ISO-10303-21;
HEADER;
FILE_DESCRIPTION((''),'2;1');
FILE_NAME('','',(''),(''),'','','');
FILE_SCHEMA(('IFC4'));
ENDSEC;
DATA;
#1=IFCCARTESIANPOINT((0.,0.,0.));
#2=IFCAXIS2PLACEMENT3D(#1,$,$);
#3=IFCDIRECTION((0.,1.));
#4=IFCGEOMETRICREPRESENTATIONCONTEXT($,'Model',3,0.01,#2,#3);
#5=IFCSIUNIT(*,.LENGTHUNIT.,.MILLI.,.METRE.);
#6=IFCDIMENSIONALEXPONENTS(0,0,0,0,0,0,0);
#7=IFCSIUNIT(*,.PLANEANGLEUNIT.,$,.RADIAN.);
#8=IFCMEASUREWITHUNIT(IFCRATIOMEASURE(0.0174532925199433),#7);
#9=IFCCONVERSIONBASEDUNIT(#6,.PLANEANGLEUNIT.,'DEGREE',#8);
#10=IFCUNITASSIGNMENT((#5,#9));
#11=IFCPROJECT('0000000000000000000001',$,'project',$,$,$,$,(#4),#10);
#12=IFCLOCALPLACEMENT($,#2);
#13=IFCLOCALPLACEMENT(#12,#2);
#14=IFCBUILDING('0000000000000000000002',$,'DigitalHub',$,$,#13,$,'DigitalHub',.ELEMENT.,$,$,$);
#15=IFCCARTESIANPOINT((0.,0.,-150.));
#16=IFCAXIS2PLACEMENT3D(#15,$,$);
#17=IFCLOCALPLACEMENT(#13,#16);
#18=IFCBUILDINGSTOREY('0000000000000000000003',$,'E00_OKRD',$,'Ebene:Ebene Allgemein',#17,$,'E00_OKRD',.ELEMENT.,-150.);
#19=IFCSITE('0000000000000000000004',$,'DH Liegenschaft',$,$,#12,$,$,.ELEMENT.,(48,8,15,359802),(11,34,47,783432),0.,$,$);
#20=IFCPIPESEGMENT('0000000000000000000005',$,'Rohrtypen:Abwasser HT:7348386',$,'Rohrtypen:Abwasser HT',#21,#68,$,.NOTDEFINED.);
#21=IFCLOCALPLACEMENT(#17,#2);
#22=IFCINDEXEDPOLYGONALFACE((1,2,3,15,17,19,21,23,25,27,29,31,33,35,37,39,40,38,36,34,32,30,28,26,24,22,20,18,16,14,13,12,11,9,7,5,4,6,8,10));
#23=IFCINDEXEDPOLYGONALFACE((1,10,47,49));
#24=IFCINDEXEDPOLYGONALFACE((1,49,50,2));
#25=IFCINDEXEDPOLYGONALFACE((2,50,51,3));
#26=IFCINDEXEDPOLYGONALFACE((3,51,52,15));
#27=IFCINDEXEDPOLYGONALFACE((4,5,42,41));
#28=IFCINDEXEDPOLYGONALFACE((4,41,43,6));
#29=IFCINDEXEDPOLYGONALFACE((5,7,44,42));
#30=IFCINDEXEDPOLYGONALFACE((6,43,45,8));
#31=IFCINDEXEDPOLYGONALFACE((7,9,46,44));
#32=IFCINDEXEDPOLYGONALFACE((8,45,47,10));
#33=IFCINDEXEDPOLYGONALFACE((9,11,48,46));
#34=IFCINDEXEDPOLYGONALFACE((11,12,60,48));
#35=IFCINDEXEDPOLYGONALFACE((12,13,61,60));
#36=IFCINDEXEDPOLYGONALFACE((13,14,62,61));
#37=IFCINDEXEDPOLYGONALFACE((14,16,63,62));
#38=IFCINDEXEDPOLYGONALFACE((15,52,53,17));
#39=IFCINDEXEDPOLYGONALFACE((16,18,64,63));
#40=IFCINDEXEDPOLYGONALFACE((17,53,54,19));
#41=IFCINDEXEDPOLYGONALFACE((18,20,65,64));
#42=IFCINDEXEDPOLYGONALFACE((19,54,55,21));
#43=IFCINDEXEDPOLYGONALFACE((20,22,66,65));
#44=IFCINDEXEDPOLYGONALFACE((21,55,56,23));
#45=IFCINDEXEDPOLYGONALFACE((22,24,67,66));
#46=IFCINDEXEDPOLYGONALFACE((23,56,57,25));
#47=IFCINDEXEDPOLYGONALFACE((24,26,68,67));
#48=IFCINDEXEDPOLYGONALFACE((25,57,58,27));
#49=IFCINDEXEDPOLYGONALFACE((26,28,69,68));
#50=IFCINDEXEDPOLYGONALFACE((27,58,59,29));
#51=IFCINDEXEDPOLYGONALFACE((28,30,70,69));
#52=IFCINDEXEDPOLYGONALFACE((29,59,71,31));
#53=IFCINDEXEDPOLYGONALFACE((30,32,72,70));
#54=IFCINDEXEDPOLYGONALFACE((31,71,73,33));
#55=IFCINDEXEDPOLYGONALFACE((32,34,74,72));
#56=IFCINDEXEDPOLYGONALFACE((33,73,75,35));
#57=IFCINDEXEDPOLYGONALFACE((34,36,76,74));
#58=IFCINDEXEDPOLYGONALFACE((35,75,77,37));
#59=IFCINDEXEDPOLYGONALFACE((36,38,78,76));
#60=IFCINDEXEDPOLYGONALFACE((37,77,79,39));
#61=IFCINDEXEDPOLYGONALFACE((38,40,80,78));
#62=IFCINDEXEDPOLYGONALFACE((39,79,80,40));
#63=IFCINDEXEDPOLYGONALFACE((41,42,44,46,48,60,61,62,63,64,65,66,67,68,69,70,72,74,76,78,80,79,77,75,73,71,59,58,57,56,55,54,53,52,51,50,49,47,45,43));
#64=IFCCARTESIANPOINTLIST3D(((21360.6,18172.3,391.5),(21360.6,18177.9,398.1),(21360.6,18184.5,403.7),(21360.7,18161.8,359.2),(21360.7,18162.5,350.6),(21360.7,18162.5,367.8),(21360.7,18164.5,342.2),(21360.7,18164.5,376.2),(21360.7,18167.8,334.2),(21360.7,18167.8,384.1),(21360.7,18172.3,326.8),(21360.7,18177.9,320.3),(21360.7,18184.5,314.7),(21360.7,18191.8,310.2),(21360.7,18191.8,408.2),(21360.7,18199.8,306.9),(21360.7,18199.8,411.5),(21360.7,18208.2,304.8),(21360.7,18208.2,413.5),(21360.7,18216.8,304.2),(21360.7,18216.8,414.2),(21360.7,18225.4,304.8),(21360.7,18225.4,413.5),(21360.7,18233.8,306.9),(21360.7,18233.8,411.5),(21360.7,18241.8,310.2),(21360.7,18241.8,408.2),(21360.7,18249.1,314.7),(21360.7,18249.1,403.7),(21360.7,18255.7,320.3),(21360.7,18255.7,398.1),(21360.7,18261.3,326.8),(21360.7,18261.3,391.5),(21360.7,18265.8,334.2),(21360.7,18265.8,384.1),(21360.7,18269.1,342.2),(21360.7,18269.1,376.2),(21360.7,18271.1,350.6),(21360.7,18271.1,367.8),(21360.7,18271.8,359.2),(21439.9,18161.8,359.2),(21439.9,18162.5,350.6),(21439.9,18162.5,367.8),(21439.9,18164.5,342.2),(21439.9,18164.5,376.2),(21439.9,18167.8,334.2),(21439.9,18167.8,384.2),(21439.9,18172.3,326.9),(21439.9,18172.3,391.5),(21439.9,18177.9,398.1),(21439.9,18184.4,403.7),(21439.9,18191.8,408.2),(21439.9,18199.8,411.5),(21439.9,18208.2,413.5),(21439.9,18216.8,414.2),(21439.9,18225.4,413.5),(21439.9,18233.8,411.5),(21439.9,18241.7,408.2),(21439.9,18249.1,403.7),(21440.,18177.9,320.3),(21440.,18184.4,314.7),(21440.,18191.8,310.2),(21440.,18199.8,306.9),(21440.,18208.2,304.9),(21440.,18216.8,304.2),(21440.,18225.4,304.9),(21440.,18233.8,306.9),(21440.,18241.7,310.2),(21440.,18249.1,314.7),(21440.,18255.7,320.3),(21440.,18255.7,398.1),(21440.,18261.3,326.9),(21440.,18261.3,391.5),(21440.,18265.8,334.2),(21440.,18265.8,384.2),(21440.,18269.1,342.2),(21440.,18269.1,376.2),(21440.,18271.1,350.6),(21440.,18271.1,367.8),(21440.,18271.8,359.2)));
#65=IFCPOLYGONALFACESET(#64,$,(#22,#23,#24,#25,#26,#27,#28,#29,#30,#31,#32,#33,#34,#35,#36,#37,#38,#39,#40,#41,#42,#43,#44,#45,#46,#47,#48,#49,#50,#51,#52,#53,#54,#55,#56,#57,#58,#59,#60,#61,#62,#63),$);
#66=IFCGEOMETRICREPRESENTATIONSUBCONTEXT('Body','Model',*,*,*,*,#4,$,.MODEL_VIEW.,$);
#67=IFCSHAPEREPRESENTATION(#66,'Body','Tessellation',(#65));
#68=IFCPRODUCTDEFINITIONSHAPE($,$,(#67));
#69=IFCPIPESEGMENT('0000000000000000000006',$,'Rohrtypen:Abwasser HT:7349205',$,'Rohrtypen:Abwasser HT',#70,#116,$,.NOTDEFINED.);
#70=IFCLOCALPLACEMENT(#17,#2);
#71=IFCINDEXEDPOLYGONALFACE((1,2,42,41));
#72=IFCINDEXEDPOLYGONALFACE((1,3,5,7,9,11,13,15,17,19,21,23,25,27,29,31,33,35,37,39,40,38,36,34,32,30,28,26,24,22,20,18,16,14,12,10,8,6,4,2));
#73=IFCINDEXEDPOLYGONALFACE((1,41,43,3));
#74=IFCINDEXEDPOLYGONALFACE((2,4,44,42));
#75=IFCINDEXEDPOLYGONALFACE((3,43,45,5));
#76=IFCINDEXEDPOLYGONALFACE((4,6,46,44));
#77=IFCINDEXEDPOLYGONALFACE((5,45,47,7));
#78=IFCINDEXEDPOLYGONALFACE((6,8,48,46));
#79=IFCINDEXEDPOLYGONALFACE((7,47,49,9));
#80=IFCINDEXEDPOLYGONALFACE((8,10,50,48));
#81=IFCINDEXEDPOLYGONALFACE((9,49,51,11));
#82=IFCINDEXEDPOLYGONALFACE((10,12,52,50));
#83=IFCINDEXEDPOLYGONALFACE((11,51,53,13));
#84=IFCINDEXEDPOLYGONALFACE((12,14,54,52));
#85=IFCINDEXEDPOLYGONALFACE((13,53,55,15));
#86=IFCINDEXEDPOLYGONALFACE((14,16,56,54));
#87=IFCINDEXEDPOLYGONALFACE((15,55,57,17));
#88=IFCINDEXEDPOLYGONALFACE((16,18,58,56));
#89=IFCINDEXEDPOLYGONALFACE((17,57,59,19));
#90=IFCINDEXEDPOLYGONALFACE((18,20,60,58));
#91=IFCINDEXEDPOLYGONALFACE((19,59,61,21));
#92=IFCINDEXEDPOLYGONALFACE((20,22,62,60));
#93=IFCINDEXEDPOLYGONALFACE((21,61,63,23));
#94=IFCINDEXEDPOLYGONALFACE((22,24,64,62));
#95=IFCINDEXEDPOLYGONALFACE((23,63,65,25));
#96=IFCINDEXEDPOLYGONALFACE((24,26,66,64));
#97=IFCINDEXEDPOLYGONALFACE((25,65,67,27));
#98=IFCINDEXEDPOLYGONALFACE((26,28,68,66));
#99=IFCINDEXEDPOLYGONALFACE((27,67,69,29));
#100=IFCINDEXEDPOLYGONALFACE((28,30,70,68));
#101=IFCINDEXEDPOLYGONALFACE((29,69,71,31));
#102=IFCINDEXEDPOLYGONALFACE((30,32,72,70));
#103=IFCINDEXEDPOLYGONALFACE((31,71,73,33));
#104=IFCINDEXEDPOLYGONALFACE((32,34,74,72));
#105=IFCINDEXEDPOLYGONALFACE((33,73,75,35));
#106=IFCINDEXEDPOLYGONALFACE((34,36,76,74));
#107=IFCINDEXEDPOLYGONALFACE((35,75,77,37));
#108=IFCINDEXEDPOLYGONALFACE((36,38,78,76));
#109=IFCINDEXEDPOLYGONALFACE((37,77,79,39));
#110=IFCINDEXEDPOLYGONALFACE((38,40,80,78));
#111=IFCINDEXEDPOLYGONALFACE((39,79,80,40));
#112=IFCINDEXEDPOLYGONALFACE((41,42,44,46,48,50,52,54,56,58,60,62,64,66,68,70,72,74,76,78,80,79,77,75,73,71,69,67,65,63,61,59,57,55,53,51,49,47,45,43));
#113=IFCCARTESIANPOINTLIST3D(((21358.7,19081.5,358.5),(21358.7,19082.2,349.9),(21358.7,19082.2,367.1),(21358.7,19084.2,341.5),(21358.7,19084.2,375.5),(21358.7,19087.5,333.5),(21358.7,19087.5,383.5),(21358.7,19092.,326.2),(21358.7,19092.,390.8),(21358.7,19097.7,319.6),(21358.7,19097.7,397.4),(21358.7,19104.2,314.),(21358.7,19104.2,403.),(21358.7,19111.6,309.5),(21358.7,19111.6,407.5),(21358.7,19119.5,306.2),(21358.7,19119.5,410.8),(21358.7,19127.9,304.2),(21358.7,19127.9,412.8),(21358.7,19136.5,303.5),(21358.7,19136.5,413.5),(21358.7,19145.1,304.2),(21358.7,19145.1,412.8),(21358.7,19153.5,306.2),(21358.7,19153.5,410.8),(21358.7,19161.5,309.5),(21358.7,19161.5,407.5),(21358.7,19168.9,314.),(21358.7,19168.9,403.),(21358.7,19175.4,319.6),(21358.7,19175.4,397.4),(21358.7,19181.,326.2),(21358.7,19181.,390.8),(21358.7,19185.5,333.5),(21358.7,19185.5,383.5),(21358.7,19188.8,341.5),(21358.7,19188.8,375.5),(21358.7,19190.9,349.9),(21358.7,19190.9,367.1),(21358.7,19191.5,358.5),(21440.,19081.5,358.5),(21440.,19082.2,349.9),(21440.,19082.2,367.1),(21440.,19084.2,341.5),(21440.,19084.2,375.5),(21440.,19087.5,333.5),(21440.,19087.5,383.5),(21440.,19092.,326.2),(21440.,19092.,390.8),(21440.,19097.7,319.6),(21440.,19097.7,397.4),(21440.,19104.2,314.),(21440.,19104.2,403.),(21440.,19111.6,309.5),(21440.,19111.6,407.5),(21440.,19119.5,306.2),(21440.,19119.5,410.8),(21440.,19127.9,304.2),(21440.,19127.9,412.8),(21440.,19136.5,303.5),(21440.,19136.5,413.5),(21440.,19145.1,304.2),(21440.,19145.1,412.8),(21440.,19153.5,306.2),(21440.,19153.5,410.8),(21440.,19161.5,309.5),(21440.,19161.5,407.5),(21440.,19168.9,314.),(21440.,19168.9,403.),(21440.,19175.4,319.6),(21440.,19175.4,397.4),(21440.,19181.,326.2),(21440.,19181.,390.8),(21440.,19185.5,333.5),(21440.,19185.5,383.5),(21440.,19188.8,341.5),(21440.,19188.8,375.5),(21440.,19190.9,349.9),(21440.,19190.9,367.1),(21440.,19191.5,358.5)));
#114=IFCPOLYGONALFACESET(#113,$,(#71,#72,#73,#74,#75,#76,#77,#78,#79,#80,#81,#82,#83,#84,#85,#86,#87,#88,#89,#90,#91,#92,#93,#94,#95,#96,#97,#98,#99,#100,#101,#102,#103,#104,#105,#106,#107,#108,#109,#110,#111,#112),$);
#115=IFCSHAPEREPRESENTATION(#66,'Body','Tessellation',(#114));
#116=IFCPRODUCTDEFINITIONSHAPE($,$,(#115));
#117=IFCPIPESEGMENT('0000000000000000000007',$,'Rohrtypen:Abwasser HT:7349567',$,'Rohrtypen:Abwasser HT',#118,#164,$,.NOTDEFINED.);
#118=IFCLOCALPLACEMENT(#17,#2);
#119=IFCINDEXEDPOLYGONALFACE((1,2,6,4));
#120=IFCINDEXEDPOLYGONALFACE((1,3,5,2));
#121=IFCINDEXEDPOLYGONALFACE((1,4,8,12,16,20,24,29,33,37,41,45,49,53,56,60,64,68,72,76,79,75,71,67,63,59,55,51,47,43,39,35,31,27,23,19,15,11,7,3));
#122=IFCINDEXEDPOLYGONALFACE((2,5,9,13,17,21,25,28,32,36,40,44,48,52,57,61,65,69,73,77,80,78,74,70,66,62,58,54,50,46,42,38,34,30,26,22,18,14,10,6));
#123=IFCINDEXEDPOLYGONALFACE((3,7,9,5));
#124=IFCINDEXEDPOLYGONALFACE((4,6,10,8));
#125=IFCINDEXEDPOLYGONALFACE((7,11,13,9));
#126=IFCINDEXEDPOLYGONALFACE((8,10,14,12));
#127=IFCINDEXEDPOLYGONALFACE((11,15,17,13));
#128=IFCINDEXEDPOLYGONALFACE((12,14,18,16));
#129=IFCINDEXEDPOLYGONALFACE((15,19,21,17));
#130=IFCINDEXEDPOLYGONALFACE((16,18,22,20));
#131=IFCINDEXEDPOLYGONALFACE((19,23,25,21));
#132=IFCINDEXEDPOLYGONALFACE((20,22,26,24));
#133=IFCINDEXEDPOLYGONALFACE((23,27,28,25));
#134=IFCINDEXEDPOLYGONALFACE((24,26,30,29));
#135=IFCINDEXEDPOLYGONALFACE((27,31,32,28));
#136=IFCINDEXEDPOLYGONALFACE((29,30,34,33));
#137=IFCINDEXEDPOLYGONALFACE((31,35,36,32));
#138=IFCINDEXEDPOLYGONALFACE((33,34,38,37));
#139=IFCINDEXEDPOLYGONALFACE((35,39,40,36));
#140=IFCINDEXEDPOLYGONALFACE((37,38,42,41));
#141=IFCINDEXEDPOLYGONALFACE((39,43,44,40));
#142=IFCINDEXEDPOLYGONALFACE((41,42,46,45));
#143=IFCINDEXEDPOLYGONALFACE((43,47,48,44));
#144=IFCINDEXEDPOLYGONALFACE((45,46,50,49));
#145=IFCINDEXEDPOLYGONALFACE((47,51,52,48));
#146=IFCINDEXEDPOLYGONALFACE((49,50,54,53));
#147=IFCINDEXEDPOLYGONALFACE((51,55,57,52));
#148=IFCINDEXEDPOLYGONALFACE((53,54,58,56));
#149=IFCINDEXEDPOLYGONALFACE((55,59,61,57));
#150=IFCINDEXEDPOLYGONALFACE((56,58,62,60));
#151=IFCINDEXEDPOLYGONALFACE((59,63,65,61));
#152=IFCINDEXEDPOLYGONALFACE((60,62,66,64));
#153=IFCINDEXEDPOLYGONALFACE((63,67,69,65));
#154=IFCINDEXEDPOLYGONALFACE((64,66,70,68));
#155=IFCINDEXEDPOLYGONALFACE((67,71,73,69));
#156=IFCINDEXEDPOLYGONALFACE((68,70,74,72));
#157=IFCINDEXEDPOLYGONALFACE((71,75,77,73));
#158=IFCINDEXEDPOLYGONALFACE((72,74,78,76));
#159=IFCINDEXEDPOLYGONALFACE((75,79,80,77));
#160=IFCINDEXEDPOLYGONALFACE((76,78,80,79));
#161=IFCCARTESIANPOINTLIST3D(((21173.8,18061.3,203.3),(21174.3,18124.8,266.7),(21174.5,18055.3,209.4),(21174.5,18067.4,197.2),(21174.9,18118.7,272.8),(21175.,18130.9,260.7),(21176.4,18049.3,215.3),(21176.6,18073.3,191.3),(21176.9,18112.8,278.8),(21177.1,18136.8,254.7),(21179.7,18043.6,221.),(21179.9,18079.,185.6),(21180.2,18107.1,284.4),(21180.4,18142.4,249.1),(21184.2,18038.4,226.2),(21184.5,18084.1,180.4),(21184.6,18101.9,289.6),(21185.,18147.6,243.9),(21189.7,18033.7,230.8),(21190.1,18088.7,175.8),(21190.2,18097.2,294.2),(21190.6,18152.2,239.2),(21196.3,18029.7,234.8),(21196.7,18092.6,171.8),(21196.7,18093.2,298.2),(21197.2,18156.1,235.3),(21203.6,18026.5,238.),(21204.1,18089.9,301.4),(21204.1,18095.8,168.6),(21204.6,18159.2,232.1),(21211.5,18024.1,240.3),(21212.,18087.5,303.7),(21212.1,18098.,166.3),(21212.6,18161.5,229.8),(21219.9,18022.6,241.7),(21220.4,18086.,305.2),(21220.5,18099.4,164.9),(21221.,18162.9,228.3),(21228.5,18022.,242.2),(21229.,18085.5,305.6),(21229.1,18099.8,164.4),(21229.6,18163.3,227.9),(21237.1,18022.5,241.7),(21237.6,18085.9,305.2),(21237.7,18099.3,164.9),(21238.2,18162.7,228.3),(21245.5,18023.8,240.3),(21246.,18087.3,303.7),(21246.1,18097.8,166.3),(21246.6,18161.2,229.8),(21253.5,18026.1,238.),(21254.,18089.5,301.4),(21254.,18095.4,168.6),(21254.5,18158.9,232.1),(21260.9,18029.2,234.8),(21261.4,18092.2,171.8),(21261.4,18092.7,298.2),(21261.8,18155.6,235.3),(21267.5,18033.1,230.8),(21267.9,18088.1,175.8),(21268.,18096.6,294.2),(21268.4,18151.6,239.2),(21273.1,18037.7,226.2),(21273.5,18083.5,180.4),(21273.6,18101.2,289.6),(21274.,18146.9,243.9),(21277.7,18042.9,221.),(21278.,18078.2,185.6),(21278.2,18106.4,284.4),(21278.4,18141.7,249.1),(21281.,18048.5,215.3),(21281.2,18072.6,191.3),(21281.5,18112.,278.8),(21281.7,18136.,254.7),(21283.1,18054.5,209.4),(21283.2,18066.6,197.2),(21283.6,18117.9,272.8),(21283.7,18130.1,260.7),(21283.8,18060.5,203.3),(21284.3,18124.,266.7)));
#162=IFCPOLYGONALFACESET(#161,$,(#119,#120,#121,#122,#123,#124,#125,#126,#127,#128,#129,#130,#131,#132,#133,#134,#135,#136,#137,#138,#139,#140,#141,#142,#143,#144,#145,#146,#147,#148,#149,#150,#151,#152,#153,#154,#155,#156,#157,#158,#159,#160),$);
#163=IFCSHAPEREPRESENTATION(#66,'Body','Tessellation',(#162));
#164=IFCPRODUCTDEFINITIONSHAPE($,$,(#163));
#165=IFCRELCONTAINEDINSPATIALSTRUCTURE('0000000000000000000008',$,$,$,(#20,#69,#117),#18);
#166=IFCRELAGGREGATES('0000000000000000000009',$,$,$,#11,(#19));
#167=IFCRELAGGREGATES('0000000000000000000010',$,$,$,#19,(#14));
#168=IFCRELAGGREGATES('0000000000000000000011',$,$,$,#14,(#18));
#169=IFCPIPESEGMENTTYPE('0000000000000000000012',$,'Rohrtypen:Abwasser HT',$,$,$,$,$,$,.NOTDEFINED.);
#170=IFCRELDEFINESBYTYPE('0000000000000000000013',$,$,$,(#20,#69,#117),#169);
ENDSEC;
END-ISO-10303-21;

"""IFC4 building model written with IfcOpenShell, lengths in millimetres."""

from ifc_helpers import new_model, entity, si_unit, converted_unit, direction, frame, origin, place, context, subcontext, project, spatial, indexed_curve, outline, extrude, type_object, element, save


model = new_model("IFC4")

# Units and contexts
model_context = context("Model", 3, precision=0.01, world=origin(), true_north=direction((0.0, 1.0)))
body_context = subcontext(model_context, "Body", "Model", "MODEL_VIEW")
ifc_project = project(units=[si_unit("LENGTHUNIT", "METRE", prefix="MILLI"), converted_unit("PLANEANGLEUNIT", "DEGREE", entity("IfcRatioMeasure", 0.0174532925199433), si_unit("PLANEANGLEUNIT", "RADIAN"), dimensions=[0, 0, 0, 0, 0, 0, 0])], contexts=[model_context])

# Site, building, storey
site_placement = place(None, origin())
site = spatial("IfcSite", under=ifc_project, at=site_placement, Name="DH Liegenschaft", CompositionType="ELEMENT", RefLatitude=(48, 8, 15, 359802), RefLongitude=(11, 34, 47, 783432), RefElevation=0.0)
building_placement = place(site_placement, origin())
building = spatial("IfcBuilding", under=site, at=building_placement, Name="DigitalHub", LongName="DigitalHub", CompositionType="ELEMENT")
storey_placement = place(building_placement, frame((0.0, 0.0, -150.0)))
storey = spatial("IfcBuildingStorey", under=building, at=storey_placement, Name="E00_OKRD", ObjectType="Ebene:Ebene Allgemein", LongName="E00_OKRD", CompositionType="ELEMENT", Elevation=-150.0)

# Pipe segments
pipe_segment_type_1 = type_object("IfcPipeSegmentType", Name="Rohrtypen:Abwasser HT", PredefinedType="NOTDEFINED")
pipe_segment_1_placement = place(storey_placement, frame((21360.6, 18160.2, 302.6)))
element("IfcPipeSegment", 1, at=pipe_segment_1_placement, inside=storey, type_object=pipe_segment_type_1, Name="Rohrtypen:Abwasser HT:7348386", ObjectType="Rohrtypen:Abwasser HT", PredefinedType="NOTDEFINED", context=body_context, shape_type="SweptSolid", body=[
    extrude(outline(indexed_curve([(55.0, 0.0), (54.3, 8.6), (52.3, 17.0), (49.0, 25.0), (44.5, 32.3), (38.9, 38.9), (32.3, 44.5), (25.0, 49.0), (17.0, 52.3), (8.6, 54.3), (0.0, 55.0), (-8.6, 54.3), (-17.0, 52.3), (-25.0, 49.0), (-32.3, 44.5), (-38.9, 38.9), (-44.5, 32.3), (-49.0, 25.0), (-52.3, 17.0), (-54.3, 8.6), (-55.0, 0.0), (-54.3, -8.6), (-52.3, -17.0), (-49.0, -25.0), (-44.5, -32.3), (-38.9, -38.9), (-32.3, -44.5), (-25.0, -49.0), (-17.0, -52.3), (-8.6, -54.3), (0.0, -55.0), (8.6, -54.3), (17.0, -52.3), (25.0, -49.0), (32.3, -44.5), (38.9, -38.9), (44.5, -32.3), (49.0, -25.0), (52.3, -17.0), (54.3, -8.6), (55.0, 0.0)], self_intersect=False)), frame((0.0, 56.6, 56.6), z_axis=(1.0, -0.000427, 0.000427), x_axis=(0.000427, 1.0, 0.0)), (0.0, 0.0, 1.0), 79.3),
])
pipe_segment_2_placement = place(storey_placement, frame((21358.7, 19079.9, 301.9)))
element("IfcPipeSegment", 2, at=pipe_segment_2_placement, inside=storey, type_object=pipe_segment_type_1, Name="Rohrtypen:Abwasser HT:7349205", ObjectType="Rohrtypen:Abwasser HT", PredefinedType="NOTDEFINED", context=body_context, shape_type="SweptSolid", body=[
    extrude(outline(indexed_curve([(55.0, 0.0), (54.3, 8.6), (52.3, 17.0), (49.0, 25.0), (44.5, 32.3), (38.9, 38.9), (32.3, 44.5), (25.0, 49.0), (17.0, 52.3), (8.6, 54.3), (0.0, 55.0), (-8.6, 54.3), (-17.0, 52.3), (-25.0, 49.0), (-32.3, 44.5), (-38.9, 38.9), (-44.5, 32.3), (-49.0, 25.0), (-52.3, 17.0), (-54.3, 8.6), (-55.0, 0.0), (-54.3, -8.6), (-52.3, -17.0), (-49.0, -25.0), (-44.5, -32.3), (-38.9, -38.9), (-32.3, -44.5), (-25.0, -49.0), (-17.0, -52.3), (-8.6, -54.3), (0.0, -55.0), (8.6, -54.3), (17.0, -52.3), (25.0, -49.0), (32.3, -44.5), (38.9, -38.9), (44.5, -32.3), (49.0, -25.0), (52.3, -17.0), (54.3, -8.6), (55.0, 0.0)], self_intersect=False)), frame((0.0, 56.6, 56.6), z_axis=(1.0, 0.0, 0.0), x_axis=(0.0, 1.0, 0.0)), (0.0, 0.0, 1.0), 81.3),
])
pipe_segment_3_placement = place(storey_placement, frame((21172.2, 18020.5, 162.8)))
element("IfcPipeSegment", 3, at=pipe_segment_3_placement, inside=storey, type_object=pipe_segment_type_1, Name="Rohrtypen:Abwasser HT:7349567", ObjectType="Rohrtypen:Abwasser HT", PredefinedType="NOTDEFINED", context=body_context, shape_type="SweptSolid", body=[
    extrude(outline(indexed_curve([(55.0, 0.0), (54.3, 8.6), (52.3, 17.0), (49.0, 25.0), (44.5, 32.3), (38.9, 38.9), (32.3, 44.5), (25.0, 49.0), (17.0, 52.3), (8.6, 54.3), (0.0, 55.0), (-8.6, 54.3), (-17.0, 52.3), (-25.0, 49.0), (-32.3, 44.5), (-38.9, 38.9), (-44.5, 32.3), (-49.0, 25.0), (-52.3, 17.0), (-54.3, 8.6), (-55.0, 0.0), (-54.3, -8.6), (-52.3, -17.0), (-49.0, -25.0), (-44.5, -32.3), (-38.9, -38.9), (-32.3, -44.5), (-25.0, -49.0), (-17.0, -52.3), (-8.6, -54.3), (0.0, -55.0), (8.6, -54.3), (17.0, -52.3), (25.0, -49.0), (32.3, -44.5), (38.9, -38.9), (44.5, -32.3), (49.0, -25.0), (52.3, -17.0), (54.3, -8.6), (55.0, 0.0)], self_intersect=False)), frame((56.6, 40.5, 40.5), z_axis=(0.005242, 0.707101, 0.707093), x_axis=(-0.999973, 0.007413, 0.0)), (0.0, 0.0, 1.0), 89.7),
])

save(model, "model.ifc")
